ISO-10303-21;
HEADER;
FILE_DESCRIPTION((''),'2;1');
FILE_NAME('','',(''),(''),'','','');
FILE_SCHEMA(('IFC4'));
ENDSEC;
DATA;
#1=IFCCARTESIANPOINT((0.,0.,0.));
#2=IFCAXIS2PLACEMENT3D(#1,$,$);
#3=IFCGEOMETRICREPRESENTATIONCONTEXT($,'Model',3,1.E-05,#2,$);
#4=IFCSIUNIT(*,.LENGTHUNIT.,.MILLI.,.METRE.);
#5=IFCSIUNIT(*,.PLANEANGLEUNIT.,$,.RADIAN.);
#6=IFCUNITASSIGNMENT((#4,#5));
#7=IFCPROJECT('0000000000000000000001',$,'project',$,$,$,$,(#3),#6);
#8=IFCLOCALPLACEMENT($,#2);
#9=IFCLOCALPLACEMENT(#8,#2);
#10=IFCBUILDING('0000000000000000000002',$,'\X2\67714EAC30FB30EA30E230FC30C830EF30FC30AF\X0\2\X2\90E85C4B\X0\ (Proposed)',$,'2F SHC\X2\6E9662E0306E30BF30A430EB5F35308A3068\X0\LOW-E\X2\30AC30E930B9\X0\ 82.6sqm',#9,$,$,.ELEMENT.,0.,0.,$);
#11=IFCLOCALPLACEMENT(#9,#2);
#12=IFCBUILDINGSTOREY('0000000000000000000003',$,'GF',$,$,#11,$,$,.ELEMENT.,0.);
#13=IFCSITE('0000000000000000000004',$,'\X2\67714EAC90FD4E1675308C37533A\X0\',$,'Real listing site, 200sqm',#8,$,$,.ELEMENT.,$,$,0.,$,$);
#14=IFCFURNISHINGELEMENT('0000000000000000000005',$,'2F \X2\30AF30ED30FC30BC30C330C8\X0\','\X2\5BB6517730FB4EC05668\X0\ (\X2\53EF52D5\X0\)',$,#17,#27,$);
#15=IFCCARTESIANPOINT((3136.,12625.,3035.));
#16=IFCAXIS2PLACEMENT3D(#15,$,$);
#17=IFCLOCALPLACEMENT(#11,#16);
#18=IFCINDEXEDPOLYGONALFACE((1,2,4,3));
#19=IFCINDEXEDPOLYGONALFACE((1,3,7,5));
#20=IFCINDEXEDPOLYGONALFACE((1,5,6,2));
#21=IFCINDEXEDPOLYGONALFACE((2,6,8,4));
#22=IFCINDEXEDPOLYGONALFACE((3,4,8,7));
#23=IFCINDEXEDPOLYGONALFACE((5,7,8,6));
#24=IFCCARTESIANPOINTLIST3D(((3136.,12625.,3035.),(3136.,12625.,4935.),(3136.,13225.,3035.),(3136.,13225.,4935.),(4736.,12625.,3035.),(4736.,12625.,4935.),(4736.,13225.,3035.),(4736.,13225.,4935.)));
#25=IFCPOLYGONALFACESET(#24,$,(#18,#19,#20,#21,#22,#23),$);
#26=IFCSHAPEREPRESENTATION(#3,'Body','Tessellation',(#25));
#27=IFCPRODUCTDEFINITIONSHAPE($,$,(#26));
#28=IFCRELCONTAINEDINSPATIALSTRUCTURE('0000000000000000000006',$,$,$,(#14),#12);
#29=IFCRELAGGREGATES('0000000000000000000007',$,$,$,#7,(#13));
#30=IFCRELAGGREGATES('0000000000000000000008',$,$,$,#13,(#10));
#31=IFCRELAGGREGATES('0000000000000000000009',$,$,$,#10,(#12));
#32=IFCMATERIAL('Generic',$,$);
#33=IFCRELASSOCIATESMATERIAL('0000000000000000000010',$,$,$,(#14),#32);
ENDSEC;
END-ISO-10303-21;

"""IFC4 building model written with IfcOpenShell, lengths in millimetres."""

from ifc_helpers import new_model, si_unit, frame, frame_2d, origin, place, context, project, spatial, rectangle, extrude, material, element, save


model = new_model("IFC4")

# Units and contexts
model_context = context("Model", 3, precision=1e-05, world=origin())
ifc_project = project(units=[si_unit("LENGTHUNIT", "METRE", prefix="MILLI"), si_unit("PLANEANGLEUNIT", "RADIAN")], contexts=[model_context])

# Site, building, storey
site_placement = place(None, origin())
site = spatial("IfcSite", under=ifc_project, at=site_placement, Name="東京都世田谷区", ObjectType="Real listing site, 200sqm", CompositionType="ELEMENT", RefElevation=0.0)
building_placement = place(site_placement, origin())
building = spatial("IfcBuilding", under=site, at=building_placement, Name="東京・リモートワーク2部屋 (Proposed)", ObjectType="2F SHC準拠のタイル張りとLOW-Eガラス 82.6sqm", CompositionType="ELEMENT", ElevationOfRefHeight=0.0, ElevationOfTerrain=0.0)
storey_placement = place(building_placement, origin())
storey = spatial("IfcBuildingStorey", under=building, at=storey_placement, Name="GF", CompositionType="ELEMENT", Elevation=0.0)

# Shared definitions
ifc_material_1 = material(Name="Generic")

# Furnishing element
furnishing_placement = place(storey_placement, frame((3136.0, 12625.0, 3035.0)))
element("IfcFurnishingElement", 1, at=furnishing_placement, inside=storey, material=ifc_material_1, Name="2F クローゼット", Description="家具・什器 (可動)", context=model_context, shape_type="SweptSolid", body=[
    extrude(rectangle(XDim=1600.0, YDim=600.0, at=frame_2d((800.0, 300.0))), frame((3136.0, 12625.0, 3035.0)), (0.0, 0.0, 1.0), 1900.0),
])

save(model, "model.ifc")
